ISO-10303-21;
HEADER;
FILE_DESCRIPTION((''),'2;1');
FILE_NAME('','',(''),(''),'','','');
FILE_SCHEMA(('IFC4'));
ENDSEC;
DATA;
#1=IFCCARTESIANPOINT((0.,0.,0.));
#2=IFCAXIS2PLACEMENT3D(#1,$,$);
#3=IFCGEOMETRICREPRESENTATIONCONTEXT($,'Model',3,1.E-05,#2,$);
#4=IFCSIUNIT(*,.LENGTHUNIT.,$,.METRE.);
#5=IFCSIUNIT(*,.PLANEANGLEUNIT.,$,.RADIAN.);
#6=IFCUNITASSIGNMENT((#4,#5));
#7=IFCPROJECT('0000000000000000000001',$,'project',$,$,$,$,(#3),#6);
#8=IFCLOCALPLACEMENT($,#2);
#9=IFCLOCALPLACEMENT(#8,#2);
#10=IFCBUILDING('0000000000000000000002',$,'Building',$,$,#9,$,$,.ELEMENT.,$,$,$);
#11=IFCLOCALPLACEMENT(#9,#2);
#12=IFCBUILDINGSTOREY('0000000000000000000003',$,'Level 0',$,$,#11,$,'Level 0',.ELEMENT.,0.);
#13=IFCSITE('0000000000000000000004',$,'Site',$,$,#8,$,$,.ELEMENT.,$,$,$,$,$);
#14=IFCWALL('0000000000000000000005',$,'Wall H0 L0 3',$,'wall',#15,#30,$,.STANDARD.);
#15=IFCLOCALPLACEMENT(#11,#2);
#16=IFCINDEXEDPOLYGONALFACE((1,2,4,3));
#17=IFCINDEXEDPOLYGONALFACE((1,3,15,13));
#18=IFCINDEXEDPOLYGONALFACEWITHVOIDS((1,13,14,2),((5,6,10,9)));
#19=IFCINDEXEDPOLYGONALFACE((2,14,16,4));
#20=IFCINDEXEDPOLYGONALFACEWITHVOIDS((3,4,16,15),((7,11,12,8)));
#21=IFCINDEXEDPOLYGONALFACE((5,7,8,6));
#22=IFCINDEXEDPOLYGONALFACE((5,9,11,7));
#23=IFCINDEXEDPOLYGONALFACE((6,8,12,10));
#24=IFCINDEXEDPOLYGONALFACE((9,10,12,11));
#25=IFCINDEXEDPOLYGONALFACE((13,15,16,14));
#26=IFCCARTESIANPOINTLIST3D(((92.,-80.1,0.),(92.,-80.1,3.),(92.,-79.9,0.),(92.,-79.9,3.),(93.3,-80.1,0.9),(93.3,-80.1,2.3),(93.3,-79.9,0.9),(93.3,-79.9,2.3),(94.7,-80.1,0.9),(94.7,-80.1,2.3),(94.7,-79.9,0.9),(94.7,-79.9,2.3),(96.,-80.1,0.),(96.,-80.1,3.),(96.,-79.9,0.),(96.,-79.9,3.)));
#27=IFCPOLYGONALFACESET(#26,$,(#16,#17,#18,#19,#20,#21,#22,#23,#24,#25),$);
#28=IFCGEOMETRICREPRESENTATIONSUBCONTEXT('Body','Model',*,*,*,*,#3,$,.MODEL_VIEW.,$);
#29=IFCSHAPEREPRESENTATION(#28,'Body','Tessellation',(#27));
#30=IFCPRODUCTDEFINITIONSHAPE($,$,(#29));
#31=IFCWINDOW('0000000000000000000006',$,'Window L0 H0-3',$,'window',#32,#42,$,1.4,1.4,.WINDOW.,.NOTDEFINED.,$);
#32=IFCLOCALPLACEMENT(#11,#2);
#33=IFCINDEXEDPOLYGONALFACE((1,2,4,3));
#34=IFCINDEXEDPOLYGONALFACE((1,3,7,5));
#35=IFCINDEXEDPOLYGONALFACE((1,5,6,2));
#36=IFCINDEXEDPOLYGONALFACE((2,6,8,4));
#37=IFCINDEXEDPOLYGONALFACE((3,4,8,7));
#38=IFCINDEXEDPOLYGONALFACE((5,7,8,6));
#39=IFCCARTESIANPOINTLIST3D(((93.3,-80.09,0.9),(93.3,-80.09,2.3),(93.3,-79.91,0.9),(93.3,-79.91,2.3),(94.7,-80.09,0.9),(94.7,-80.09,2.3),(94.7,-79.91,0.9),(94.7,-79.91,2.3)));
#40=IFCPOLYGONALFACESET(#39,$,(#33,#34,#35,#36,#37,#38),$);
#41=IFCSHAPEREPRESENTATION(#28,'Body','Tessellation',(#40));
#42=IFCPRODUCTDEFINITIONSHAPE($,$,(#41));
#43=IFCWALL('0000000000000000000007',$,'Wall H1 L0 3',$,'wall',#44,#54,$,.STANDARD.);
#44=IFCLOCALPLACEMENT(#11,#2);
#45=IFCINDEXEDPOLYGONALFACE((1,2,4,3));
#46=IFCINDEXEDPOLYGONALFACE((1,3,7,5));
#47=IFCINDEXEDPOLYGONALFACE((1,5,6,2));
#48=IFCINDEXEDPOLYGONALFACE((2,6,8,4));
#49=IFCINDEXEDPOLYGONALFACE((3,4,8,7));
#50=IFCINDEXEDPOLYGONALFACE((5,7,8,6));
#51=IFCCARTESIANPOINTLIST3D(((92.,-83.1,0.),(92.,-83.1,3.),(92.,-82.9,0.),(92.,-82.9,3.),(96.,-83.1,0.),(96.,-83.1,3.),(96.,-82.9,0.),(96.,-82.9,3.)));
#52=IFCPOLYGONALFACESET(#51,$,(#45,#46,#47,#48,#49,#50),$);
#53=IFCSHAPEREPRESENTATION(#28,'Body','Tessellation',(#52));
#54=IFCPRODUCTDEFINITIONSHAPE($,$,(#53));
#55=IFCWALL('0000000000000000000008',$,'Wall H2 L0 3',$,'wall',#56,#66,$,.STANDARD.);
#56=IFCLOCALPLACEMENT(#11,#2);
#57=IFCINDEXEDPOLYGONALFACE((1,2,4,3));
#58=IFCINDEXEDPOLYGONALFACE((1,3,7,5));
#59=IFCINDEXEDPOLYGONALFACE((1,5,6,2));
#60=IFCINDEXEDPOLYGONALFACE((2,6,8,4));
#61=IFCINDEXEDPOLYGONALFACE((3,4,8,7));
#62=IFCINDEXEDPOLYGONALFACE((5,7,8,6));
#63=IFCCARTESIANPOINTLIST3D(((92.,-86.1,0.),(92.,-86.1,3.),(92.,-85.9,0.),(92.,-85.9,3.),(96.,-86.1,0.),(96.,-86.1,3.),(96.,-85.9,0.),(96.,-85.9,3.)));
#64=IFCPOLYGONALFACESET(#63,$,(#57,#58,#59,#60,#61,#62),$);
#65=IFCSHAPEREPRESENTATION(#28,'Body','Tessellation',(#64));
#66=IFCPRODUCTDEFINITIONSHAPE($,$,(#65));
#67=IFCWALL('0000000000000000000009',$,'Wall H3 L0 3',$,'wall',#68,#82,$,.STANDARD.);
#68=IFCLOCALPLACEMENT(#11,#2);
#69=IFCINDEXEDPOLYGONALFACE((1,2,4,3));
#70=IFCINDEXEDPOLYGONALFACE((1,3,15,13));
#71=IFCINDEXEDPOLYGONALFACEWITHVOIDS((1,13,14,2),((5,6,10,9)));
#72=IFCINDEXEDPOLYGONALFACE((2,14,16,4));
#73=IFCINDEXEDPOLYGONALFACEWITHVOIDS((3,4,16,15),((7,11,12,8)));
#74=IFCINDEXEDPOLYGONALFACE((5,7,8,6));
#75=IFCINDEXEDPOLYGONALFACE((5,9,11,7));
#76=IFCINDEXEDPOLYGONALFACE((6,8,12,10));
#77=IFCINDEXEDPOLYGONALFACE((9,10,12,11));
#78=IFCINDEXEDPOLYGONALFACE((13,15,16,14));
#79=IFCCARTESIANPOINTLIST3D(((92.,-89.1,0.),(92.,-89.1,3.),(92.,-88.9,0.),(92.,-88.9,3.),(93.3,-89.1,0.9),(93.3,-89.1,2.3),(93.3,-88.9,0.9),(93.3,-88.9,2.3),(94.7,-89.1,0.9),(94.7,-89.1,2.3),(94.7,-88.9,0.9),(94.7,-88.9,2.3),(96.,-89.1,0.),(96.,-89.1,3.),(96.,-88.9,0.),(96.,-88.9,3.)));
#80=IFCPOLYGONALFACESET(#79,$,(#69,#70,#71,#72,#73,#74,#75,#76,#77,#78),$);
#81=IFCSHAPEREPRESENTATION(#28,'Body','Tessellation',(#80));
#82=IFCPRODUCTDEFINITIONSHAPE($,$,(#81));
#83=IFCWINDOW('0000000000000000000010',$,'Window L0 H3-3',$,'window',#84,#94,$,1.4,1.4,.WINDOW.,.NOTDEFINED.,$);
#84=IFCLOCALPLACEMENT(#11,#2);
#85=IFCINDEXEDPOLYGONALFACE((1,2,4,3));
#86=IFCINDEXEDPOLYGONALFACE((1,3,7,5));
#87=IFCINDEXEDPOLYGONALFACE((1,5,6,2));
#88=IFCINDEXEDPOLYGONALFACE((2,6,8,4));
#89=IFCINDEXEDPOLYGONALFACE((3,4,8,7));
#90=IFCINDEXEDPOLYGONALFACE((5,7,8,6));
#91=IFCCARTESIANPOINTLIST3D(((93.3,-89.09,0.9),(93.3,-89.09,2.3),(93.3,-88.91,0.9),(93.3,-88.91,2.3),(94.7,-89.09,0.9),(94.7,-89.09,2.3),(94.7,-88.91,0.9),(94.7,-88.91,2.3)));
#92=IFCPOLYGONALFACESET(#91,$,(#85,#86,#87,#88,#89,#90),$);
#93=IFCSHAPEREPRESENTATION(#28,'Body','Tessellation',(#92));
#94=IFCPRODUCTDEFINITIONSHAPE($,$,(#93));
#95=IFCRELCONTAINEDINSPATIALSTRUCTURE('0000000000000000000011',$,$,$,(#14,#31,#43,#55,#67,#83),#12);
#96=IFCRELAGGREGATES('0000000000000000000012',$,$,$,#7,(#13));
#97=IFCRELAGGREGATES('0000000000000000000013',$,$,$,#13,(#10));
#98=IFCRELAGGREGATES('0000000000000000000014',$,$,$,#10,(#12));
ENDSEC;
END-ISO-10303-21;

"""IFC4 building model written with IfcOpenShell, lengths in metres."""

from ifc_helpers import new_model, si_unit, frame, frame_2d, origin, origin_2d, place, context, subcontext, project, spatial, rectangle, extrude, element, fill, save


model = new_model("IFC4")

# Units and contexts
model_context = context("Model", 3, precision=1e-05, world=origin())
body_context = subcontext(model_context, "Body", "Model", "MODEL_VIEW")
ifc_project = project(units=[si_unit("LENGTHUNIT", "METRE"), si_unit("PLANEANGLEUNIT", "RADIAN")], contexts=[model_context])

# Site, building, storey
site_placement = place(None, origin())
site = spatial("IfcSite", under=ifc_project, at=site_placement, Name="Site", CompositionType="ELEMENT")
building_placement = place(site_placement, origin())
building = spatial("IfcBuilding", under=site, at=building_placement, Name="Building", CompositionType="ELEMENT")
storey_placement = place(building_placement, origin())
storey = spatial("IfcBuildingStorey", under=building, at=storey_placement, Name="Level 0", LongName="Level 0", CompositionType="ELEMENT", Elevation=0.0)

# Wall, opening, window
wall_1_placement = place(storey_placement, frame((92.0, -80.0, 0.0), z_axis=(0.0, 0.0, 1.0), x_axis=(1.0, 0.0, 0.0)))
wall_1 = element("IfcWall", 1, at=wall_1_placement, inside=storey, Name="Wall H0 L0 3", ObjectType="wall", PredefinedType="STANDARD", context=body_context, shape_type="SweptSolid", body=[
    extrude(rectangle(XDim=4.0, YDim=0.2, at=frame_2d((2.0, 0.0))), origin(), (0.0, 0.0, 1.0), 3.0),
])
opening_1_placement = place(storey_placement, frame((94.0, -80.0, 0.9), z_axis=(0.0, 0.0, 1.0), x_axis=(1.0, 0.0, 0.0)))
opening_1 = element("IfcOpeningElement", 2, at=opening_1_placement, cuts=wall_1, ObjectType="Opening", PredefinedType="OPENING", context=body_context, shape_type="SweptSolid", body=[
    extrude(rectangle(XDim=1.4, YDim=0.22, at=origin_2d()), origin(), (0.0, 0.0, 1.0), 1.4),
])
window_1_placement = place(storey_placement, frame((94.0, -80.0, 0.9), z_axis=(0.0, 0.0, 1.0), x_axis=(1.0, 0.0, 0.0)))
window_1 = element("IfcWindow", 3, at=window_1_placement, inside=storey, Name="Window L0 H0-3", ObjectType="window", OverallHeight=1.4, OverallWidth=1.4, PartitioningType="NOTDEFINED", PredefinedType="WINDOW", context=body_context, shape_type="SweptSolid", body=[
    extrude(rectangle(XDim=1.4, YDim=0.18, at=origin_2d()), origin(), (0.0, 0.0, 1.0), 1.4),
])
fill(opening_1, window_1)

# Walls
for number, where, z_axis, x_axis, name in (
    (4, (92.0, -83.0, 0.0), (0.0, 0.0, 1.0), (1.0, 0.0, 0.0), "Wall H1 L0 3"),
    (5, (92.0, -86.0, 0.0), (0.0, 0.0, 1.0), (1.0, 0.0, 0.0), "Wall H2 L0 3"),
):
    element("IfcWall", number, at=place(storey_placement, frame(where, z_axis=z_axis, x_axis=x_axis)), inside=storey, Name=name, ObjectType="wall", PredefinedType="STANDARD", context=body_context, shape_type="SweptSolid", body=[
        extrude(rectangle(XDim=4.0, YDim=0.2, at=frame_2d((2.0, 0.0))), origin(), (0.0, 0.0, 1.0), 3.0),
    ])

# Wall, opening, window
wall_2_placement = place(storey_placement, frame((92.0, -89.0, 0.0), z_axis=(0.0, 0.0, 1.0), x_axis=(1.0, 0.0, 0.0)))
wall_2 = element("IfcWall", 6, at=wall_2_placement, inside=storey, Name="Wall H3 L0 3", ObjectType="wall", PredefinedType="STANDARD", context=body_context, shape_type="SweptSolid", body=[
    extrude(rectangle(XDim=4.0, YDim=0.2, at=frame_2d((2.0, 0.0))), origin(), (0.0, 0.0, 1.0), 3.0),
])
opening_2_placement = place(storey_placement, frame((94.0, -89.0, 0.9), z_axis=(0.0, 0.0, 1.0), x_axis=(1.0, 0.0, 0.0)))
opening_2 = element("IfcOpeningElement", 7, at=opening_2_placement, cuts=wall_2, ObjectType="Opening", PredefinedType="OPENING", context=body_context, shape_type="SweptSolid", body=[
    extrude(rectangle(XDim=1.4, YDim=0.22, at=origin_2d()), origin(), (0.0, 0.0, 1.0), 1.4),
])
window_2_placement = place(storey_placement, frame((94.0, -89.0, 0.9), z_axis=(0.0, 0.0, 1.0), x_axis=(1.0, 0.0, 0.0)))
window_2 = element("IfcWindow", 8, at=window_2_placement, inside=storey, Name="Window L0 H3-3", ObjectType="window", OverallHeight=1.4, OverallWidth=1.4, PartitioningType="NOTDEFINED", PredefinedType="WINDOW", context=body_context, shape_type="SweptSolid", body=[
    extrude(rectangle(XDim=1.4, YDim=0.18, at=origin_2d()), origin(), (0.0, 0.0, 1.0), 1.4),
])
fill(opening_2, window_2)

save(model, "model.ifc")
